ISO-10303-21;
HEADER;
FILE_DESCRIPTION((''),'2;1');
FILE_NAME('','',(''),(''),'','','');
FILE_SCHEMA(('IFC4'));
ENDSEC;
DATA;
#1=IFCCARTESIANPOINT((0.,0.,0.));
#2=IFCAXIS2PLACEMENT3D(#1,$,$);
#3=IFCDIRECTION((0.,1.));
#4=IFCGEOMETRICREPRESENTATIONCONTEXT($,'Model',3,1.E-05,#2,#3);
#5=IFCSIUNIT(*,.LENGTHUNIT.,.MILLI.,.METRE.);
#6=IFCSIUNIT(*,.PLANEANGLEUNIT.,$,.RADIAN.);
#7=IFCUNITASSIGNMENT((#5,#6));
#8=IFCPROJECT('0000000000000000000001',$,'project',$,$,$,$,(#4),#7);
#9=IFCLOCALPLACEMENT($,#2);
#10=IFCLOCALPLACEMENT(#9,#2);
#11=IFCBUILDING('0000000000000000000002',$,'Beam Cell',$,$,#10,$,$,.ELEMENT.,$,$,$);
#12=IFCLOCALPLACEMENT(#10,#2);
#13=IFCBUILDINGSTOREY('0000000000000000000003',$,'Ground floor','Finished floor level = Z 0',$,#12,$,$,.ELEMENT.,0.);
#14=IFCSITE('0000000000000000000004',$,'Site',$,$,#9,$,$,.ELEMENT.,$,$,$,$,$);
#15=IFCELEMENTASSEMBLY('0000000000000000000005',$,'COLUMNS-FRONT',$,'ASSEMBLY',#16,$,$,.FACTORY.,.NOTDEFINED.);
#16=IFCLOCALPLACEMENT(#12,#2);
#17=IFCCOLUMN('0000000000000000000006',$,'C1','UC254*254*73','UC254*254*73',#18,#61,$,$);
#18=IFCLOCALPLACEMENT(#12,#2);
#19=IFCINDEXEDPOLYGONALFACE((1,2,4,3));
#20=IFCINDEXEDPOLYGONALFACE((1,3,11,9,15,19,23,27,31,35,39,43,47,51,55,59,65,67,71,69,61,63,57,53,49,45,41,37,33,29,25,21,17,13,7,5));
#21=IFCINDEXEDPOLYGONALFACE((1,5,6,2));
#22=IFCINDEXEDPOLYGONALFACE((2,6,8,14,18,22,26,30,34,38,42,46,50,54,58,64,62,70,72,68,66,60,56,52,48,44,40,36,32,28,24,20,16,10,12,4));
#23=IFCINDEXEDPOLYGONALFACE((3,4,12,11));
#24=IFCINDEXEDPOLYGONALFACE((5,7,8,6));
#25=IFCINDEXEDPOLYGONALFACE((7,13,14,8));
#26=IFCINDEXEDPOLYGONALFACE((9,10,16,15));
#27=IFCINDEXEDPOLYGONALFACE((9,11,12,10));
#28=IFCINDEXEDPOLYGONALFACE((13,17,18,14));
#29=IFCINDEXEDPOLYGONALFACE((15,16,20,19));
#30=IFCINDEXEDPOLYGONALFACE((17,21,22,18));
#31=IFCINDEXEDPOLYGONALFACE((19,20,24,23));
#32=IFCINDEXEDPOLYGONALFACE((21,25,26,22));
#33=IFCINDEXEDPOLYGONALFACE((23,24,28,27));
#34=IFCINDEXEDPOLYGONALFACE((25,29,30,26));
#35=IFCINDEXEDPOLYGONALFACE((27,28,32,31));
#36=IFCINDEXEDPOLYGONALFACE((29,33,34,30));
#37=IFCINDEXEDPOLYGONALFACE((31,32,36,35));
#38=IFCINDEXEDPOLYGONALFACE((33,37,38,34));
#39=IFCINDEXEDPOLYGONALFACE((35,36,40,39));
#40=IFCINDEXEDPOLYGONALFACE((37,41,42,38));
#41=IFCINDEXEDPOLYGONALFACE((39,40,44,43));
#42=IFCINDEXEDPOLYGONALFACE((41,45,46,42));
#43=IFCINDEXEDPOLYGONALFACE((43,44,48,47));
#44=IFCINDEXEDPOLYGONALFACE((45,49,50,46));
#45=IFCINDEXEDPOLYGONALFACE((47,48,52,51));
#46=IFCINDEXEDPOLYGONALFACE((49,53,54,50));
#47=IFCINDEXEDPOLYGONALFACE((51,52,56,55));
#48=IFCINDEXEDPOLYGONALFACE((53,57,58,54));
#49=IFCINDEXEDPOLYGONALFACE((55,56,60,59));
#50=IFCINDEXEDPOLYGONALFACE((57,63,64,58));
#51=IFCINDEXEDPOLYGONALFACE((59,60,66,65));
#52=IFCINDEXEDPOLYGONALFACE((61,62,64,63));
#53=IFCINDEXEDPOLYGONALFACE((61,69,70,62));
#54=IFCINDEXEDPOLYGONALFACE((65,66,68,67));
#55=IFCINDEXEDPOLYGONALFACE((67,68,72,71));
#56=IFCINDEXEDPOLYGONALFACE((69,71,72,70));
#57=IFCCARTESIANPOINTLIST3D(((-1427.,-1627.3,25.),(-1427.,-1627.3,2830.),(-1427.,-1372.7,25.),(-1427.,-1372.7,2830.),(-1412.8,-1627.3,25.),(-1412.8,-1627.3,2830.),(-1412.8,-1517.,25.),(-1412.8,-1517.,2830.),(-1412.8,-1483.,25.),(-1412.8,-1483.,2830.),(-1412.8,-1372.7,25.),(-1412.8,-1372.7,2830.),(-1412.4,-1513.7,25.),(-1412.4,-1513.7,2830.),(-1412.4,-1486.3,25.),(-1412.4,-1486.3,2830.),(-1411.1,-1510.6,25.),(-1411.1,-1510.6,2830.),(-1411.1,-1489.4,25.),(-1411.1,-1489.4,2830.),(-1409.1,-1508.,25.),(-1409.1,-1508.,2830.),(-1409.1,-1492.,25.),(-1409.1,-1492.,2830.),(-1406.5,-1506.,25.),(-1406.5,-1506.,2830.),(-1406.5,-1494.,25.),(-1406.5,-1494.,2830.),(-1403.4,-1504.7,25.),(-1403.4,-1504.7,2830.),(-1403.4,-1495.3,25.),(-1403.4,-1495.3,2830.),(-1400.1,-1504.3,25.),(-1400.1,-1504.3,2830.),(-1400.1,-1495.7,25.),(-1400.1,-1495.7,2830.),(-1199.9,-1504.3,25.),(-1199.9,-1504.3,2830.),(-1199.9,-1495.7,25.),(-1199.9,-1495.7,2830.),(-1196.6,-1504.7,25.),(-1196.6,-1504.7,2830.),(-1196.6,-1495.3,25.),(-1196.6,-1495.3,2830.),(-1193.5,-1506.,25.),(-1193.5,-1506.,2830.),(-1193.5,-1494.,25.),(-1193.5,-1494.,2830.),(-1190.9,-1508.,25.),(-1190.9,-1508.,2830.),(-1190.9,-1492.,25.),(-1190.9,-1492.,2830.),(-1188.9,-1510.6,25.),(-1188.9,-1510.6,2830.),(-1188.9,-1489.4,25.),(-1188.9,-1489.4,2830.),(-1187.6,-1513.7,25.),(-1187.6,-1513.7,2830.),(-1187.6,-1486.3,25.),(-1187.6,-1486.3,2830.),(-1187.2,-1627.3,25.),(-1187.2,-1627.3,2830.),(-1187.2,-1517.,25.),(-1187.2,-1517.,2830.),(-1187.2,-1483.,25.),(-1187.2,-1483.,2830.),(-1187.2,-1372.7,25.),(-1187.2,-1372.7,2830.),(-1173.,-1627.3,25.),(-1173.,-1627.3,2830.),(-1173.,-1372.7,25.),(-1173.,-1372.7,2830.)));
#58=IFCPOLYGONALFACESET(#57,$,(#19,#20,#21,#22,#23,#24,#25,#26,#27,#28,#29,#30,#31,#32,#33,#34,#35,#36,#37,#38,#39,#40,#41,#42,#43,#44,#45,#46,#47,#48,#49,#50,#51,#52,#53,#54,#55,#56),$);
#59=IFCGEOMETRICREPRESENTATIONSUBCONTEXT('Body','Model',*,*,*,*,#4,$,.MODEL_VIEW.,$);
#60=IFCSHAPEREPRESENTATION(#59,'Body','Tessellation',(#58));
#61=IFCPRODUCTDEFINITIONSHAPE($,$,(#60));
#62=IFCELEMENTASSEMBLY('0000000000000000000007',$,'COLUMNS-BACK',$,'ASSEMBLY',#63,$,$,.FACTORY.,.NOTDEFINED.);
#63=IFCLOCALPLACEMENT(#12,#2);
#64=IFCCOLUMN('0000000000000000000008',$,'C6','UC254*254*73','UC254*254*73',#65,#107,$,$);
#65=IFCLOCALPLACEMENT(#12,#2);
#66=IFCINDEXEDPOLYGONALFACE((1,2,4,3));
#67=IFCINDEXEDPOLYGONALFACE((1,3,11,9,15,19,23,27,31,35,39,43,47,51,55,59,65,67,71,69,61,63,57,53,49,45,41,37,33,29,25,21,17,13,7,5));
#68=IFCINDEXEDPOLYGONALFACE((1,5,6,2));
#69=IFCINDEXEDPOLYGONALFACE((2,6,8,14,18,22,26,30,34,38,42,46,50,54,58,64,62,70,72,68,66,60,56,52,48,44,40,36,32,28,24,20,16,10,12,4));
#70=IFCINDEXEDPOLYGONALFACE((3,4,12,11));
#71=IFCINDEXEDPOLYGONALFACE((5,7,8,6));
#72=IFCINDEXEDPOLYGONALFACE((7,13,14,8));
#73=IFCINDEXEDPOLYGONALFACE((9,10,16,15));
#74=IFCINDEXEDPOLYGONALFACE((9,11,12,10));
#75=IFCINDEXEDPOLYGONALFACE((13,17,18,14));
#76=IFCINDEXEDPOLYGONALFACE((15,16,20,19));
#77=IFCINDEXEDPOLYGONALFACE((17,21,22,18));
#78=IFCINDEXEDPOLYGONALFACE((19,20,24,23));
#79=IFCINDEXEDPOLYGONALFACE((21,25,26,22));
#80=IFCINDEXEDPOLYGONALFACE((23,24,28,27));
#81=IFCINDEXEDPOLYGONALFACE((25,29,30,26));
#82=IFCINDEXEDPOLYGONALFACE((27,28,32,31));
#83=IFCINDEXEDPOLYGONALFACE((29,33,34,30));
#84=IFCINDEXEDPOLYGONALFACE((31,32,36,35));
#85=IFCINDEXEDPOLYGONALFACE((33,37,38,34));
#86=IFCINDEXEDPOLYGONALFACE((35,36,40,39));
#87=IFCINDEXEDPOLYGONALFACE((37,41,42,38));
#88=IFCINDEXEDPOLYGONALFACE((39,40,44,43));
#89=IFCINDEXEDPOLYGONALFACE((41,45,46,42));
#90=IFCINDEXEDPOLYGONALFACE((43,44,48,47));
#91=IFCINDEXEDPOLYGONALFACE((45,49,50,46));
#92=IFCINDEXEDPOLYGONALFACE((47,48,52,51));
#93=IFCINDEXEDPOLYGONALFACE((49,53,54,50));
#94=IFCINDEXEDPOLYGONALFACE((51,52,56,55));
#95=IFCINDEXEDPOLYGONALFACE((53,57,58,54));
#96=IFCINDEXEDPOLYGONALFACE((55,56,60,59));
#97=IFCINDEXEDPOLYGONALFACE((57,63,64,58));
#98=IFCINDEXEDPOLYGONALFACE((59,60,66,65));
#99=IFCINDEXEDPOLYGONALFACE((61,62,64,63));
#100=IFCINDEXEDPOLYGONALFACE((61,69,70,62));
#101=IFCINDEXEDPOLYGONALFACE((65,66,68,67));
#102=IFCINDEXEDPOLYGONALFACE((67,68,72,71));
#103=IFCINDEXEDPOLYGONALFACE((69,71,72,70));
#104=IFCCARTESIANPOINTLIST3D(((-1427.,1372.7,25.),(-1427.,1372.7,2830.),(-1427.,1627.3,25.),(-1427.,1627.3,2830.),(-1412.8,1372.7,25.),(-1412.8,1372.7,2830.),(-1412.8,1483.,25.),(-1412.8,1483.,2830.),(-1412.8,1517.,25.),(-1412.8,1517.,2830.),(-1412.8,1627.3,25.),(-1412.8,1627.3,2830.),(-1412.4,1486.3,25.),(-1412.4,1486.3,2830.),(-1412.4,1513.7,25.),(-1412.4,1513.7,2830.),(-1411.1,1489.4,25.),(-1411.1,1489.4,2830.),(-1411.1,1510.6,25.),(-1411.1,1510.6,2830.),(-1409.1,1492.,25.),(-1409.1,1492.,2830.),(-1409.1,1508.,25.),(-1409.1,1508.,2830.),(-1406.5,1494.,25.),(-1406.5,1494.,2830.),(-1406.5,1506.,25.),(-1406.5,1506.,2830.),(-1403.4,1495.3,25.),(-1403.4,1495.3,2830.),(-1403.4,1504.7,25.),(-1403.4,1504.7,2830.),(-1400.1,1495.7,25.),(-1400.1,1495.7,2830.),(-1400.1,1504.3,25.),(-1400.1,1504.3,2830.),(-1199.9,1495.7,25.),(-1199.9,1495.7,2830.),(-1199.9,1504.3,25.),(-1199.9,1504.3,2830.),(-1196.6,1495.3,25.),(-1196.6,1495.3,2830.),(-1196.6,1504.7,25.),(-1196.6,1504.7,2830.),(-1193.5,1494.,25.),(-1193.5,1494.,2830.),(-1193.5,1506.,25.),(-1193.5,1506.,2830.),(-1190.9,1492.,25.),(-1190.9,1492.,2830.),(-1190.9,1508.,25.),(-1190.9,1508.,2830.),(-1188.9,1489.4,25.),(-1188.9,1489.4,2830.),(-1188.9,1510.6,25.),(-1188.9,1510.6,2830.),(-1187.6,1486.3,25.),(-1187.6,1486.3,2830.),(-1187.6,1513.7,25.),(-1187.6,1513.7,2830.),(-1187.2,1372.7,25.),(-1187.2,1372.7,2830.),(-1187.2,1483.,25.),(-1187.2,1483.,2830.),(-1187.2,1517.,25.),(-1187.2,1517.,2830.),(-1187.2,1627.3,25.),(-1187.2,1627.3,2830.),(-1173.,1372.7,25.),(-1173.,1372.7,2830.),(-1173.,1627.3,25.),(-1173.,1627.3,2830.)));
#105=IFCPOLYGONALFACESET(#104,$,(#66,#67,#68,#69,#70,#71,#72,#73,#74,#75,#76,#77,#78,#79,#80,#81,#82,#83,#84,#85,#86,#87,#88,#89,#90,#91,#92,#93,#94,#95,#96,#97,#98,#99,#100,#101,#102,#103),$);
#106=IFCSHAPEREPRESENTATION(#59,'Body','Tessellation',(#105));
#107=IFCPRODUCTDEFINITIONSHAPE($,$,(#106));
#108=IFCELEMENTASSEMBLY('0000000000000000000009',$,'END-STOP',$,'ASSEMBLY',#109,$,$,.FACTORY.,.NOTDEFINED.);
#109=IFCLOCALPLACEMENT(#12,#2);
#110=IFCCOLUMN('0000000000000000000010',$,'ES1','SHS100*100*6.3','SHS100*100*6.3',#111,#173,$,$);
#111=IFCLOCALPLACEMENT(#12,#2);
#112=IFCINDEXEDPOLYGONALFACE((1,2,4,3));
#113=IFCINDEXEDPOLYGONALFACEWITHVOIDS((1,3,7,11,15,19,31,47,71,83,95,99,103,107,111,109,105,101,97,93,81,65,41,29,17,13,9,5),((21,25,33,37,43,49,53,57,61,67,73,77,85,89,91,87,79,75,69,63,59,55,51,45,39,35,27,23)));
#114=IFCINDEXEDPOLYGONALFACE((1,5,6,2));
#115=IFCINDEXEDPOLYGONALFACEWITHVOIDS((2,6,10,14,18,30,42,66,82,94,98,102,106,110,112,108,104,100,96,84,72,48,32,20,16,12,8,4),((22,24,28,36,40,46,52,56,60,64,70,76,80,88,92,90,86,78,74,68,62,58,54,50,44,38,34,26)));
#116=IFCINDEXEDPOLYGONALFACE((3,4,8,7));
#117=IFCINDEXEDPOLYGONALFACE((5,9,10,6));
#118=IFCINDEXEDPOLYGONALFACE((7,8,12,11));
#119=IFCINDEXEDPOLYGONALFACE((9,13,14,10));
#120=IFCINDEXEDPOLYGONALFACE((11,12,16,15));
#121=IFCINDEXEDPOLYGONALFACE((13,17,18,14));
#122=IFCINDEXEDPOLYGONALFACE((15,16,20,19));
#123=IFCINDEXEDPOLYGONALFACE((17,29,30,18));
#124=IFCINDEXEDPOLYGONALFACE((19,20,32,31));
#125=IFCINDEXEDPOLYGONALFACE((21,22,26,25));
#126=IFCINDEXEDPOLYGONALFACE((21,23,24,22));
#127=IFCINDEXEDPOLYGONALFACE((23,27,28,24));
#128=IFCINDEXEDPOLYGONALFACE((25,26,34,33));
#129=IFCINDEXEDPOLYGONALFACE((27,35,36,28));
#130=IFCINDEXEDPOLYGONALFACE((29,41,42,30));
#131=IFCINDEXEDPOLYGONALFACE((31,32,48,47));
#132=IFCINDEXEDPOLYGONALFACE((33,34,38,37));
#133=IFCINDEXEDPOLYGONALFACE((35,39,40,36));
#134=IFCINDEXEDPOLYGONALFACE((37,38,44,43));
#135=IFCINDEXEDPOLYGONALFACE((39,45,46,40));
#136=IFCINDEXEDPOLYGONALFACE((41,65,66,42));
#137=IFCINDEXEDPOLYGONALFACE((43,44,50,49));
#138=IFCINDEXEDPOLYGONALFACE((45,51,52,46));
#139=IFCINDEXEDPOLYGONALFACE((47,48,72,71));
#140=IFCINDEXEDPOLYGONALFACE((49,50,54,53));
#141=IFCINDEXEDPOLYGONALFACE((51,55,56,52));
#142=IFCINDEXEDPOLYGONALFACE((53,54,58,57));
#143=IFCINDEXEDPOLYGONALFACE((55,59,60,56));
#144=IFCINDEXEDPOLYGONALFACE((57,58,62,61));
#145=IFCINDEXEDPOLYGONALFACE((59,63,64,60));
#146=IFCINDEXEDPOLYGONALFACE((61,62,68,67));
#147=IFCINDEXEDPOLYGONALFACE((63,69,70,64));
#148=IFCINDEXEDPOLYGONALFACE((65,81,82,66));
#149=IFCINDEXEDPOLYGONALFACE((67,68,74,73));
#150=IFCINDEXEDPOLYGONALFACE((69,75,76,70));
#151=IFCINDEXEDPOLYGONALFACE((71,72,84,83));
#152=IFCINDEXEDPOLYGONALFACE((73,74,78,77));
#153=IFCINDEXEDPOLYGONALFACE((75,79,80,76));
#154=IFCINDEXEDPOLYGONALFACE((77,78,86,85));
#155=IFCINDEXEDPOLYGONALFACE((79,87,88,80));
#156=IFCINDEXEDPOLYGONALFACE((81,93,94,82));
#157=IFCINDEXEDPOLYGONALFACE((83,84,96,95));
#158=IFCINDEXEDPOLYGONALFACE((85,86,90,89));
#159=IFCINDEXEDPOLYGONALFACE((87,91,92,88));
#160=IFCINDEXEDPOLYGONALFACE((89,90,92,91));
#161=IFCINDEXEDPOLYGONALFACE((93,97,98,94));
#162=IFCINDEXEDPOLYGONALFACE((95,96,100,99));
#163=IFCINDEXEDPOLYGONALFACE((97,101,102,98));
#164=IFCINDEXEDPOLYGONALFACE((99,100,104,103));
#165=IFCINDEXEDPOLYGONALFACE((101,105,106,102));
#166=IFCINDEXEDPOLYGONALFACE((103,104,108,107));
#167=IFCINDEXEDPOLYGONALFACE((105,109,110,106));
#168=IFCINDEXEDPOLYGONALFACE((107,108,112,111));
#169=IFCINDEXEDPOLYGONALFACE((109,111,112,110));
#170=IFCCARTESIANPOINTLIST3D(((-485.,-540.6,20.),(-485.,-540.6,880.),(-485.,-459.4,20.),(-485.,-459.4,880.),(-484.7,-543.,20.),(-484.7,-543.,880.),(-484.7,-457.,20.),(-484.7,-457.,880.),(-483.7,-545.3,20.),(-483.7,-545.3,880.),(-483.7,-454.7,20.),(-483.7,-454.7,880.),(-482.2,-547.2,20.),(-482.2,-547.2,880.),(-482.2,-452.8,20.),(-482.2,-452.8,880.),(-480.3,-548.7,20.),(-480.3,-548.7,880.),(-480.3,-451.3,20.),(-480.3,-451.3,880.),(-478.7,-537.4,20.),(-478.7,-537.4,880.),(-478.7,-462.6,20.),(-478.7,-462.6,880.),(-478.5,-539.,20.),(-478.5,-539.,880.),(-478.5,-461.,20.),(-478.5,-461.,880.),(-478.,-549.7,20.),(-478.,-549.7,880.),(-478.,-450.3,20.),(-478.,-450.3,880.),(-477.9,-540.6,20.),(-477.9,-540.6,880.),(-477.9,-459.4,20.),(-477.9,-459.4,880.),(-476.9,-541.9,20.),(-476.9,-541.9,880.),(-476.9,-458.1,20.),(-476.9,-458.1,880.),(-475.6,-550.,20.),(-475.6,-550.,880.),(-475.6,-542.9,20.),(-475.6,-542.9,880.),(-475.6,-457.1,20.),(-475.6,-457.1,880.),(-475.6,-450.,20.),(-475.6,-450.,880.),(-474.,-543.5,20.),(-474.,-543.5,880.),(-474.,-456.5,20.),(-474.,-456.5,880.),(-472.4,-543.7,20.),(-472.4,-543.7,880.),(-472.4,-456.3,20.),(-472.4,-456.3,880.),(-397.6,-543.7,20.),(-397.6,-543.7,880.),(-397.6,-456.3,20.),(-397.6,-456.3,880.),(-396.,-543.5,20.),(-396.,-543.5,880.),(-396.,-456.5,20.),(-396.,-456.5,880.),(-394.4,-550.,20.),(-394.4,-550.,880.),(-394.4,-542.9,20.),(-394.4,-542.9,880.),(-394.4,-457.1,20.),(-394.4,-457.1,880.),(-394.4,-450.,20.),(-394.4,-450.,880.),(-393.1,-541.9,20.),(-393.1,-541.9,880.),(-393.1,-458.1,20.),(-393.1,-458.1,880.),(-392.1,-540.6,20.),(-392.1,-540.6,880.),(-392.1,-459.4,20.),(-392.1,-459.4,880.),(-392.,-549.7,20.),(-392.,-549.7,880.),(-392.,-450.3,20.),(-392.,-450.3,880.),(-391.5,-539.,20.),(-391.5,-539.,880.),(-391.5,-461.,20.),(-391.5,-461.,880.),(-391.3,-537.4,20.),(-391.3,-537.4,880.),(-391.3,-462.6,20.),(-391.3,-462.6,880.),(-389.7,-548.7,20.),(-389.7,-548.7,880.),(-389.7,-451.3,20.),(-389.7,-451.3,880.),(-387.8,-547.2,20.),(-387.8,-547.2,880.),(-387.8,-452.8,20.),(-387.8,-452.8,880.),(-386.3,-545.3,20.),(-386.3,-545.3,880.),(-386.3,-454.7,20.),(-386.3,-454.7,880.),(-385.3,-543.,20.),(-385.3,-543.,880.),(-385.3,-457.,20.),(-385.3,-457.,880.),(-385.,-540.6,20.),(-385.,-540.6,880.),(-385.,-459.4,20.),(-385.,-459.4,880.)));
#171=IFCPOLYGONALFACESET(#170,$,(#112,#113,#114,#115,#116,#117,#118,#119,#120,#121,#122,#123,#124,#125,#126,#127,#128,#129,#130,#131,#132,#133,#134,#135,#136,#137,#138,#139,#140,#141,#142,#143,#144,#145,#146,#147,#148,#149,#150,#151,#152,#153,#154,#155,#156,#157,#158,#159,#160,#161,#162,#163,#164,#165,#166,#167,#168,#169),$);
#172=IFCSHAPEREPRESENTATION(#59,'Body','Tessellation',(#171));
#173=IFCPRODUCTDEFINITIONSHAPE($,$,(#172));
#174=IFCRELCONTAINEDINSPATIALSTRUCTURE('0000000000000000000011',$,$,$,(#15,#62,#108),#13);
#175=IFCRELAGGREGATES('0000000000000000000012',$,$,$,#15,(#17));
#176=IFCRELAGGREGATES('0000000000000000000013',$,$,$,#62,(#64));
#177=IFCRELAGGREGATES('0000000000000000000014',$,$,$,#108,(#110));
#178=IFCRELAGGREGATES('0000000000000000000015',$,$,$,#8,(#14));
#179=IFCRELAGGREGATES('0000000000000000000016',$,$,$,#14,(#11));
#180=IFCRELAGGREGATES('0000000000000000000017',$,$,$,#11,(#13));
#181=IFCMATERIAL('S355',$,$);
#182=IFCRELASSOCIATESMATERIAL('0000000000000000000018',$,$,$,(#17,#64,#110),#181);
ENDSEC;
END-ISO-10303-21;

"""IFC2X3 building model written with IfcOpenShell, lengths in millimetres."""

from ifc_helpers import new_model, si_unit, direction, frame, origin, origin_2d, place, context, subcontext, project, spatial, hollow_rectangle, i_section, extrude, material, element, aggregate, save


model = new_model("IFC2X3")

# Units and contexts
model_context = context("Model", 3, precision=1e-05, world=origin(), true_north=direction((0.0, 1.0)))
body_context = subcontext(model_context, "Body", "Model", "MODEL_VIEW")
ifc_project = project(units=[si_unit("LENGTHUNIT", "METRE", prefix="MILLI"), si_unit("PLANEANGLEUNIT", "RADIAN")], contexts=[model_context])

# Site, building, storey
site_placement = place(None, origin())
site = spatial("IfcSite", under=ifc_project, at=site_placement, Name="Site", CompositionType="ELEMENT")
building_placement = place(site_placement, origin())
building = spatial("IfcBuilding", under=site, at=building_placement, Name="Beam Cell", CompositionType="ELEMENT")
storey_placement = place(building_placement, origin())
storey = spatial("IfcBuildingStorey", under=building, at=storey_placement, Name="Ground floor", Description="Finished floor level = Z 0", CompositionType="ELEMENT", Elevation=0.0)

# Element assemblies, columns
assembly_1_placement = place(storey_placement, origin())
assembly_1 = element("IfcElementAssembly", 1, at=assembly_1_placement, inside=storey, Name="COLUMNS-FRONT", ObjectType="ASSEMBLY", AssemblyPlace="FACTORY", PredefinedType="NOTDEFINED")
ifc_material = material(Name="S355")
column_1_placement = place(storey_placement, frame((-1300.0, -1500.0, 25.0), z_axis=(0.0, 0.0, 1.0), x_axis=(0.0, 1.0, 0.0)))
column_1 = element("IfcColumn", 2, at=column_1_placement, material=ifc_material, Name="C1", Description="UC254*254*73", ObjectType="UC254*254*73", context=body_context, shape_type="SweptSolid", body=[
    extrude(i_section(OverallWidth=254.6, OverallDepth=254.1, WebThickness=8.6, FlangeThickness=14.2, FilletRadius=12.7, at=origin_2d()), origin(), (0.0, 0.0, 1.0), 2805.0),
])
assembly_2_placement = place(storey_placement, origin())
assembly_2 = element("IfcElementAssembly", 3, at=assembly_2_placement, inside=storey, Name="COLUMNS-BACK", ObjectType="ASSEMBLY", AssemblyPlace="FACTORY", PredefinedType="NOTDEFINED")
column_2_placement = place(storey_placement, frame((-1300.0, 1500.0, 25.0), z_axis=(0.0, 0.0, 1.0), x_axis=(0.0, 1.0, 0.0)))
column_2 = element("IfcColumn", 4, at=column_2_placement, material=ifc_material, Name="C6", Description="UC254*254*73", ObjectType="UC254*254*73", context=body_context, shape_type="SweptSolid", body=[
    extrude(i_section(OverallWidth=254.6, OverallDepth=254.1, WebThickness=8.6, FlangeThickness=14.2, FilletRadius=12.7, at=origin_2d()), origin(), (0.0, 0.0, 1.0), 2805.0),
])
assembly_3_placement = place(storey_placement, origin())
assembly_3 = element("IfcElementAssembly", 5, at=assembly_3_placement, inside=storey, Name="END-STOP", ObjectType="ASSEMBLY", AssemblyPlace="FACTORY", PredefinedType="NOTDEFINED")
column_3_placement = place(storey_placement, frame((-435.0, -500.0, 20.0), z_axis=(0.0, 0.0, 1.0), x_axis=(1.0, 0.0, 0.0)))
column_3 = element("IfcColumn", 6, at=column_3_placement, material=ifc_material, Name="ES1", Description="SHS100*100*6.3", ObjectType="SHS100*100*6.3", context=body_context, shape_type="SweptSolid", body=[
    extrude(hollow_rectangle(XDim=100.0, YDim=100.0, WallThickness=6.3, InnerFilletRadius=6.3, OuterFilletRadius=9.4, at=origin_2d()), origin(), (0.0, 0.0, 1.0), 860.0),
])

aggregate(assembly_1, [column_1])
aggregate(assembly_2, [column_2])
aggregate(assembly_3, [column_3])

save(model, "model.ifc")
